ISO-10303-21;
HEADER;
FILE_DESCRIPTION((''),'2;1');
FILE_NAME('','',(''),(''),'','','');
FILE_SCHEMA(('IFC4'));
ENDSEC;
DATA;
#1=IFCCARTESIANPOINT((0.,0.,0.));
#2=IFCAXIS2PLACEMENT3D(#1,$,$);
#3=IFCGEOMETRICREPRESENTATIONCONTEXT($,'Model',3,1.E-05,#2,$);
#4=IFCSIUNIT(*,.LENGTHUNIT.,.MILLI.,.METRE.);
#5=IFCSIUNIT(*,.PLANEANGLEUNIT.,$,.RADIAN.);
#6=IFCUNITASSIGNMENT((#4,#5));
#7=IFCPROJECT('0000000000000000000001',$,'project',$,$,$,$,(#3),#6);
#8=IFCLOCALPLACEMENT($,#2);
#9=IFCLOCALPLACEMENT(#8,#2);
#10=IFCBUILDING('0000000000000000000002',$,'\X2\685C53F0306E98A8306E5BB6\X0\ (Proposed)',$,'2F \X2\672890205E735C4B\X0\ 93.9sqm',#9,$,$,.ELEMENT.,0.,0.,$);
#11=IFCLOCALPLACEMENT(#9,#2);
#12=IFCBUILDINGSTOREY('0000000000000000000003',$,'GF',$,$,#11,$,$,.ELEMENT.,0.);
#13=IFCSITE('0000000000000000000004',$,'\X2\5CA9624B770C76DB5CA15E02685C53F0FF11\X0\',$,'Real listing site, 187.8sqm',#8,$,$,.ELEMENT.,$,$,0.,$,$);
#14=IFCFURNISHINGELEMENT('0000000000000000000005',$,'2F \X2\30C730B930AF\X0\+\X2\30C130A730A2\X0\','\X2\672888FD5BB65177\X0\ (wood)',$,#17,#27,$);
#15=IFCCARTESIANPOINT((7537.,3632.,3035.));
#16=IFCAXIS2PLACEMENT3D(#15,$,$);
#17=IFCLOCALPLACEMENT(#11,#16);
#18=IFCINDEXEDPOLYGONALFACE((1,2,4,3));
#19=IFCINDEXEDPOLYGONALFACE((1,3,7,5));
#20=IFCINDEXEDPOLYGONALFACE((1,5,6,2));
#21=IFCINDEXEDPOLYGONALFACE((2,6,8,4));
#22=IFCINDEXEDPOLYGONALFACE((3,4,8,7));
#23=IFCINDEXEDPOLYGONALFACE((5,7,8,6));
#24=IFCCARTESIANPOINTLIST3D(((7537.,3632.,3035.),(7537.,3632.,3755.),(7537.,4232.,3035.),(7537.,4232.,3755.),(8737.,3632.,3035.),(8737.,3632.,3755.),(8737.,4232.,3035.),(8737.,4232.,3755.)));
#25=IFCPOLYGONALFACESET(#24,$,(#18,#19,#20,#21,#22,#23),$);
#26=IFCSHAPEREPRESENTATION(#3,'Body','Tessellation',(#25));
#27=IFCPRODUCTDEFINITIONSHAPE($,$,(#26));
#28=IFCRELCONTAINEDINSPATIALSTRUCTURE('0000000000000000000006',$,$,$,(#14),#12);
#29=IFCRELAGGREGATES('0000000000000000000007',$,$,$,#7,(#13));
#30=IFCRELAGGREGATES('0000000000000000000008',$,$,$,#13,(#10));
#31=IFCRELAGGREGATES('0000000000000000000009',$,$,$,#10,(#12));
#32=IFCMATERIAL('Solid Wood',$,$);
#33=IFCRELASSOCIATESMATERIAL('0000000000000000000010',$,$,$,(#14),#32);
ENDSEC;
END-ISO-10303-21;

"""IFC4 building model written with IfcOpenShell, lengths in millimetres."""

from ifc_helpers import new_model, si_unit, frame, frame_2d, origin, place, context, project, spatial, rectangle, extrude, material, element, save


model = new_model("IFC4")

# Units and contexts
model_context = context("Model", 3, precision=1e-05, world=origin())
ifc_project = project(units=[si_unit("LENGTHUNIT", "METRE", prefix="MILLI"), si_unit("PLANEANGLEUNIT", "RADIAN")], contexts=[model_context])

# Site, building, storey
site_placement = place(None, origin())
site = spatial("IfcSite", under=ifc_project, at=site_placement, Name="岩手県盛岡市桜台１", ObjectType="Real listing site, 187.8sqm", CompositionType="ELEMENT", RefElevation=0.0)
building_placement = place(site_placement, origin())
building = spatial("IfcBuilding", under=site, at=building_placement, Name="桜台の風の家 (Proposed)", ObjectType="2F 木造平屋 93.9sqm", CompositionType="ELEMENT", ElevationOfRefHeight=0.0, ElevationOfTerrain=0.0)
storey_placement = place(building_placement, origin())
storey = spatial("IfcBuildingStorey", under=building, at=storey_placement, Name="GF", CompositionType="ELEMENT", Elevation=0.0)

# Shared definitions
ifc_material_1 = material(Name="Solid Wood")

# Furnishing element
furnishing_1_placement = place(storey_placement, frame((7537.0, 3632.0, 3035.0)))
element("IfcFurnishingElement", 1, at=furnishing_1_placement, inside=storey, material=ifc_material_1, Name="2F デスク+チェア", Description="木製家具 (wood)", context=model_context, shape_type="SweptSolid", body=[
    extrude(rectangle(XDim=1200.0, YDim=600.0, at=frame_2d((600.0, 300.0))), frame((7537.0, 3632.0, 3035.0)), (0.0, 0.0, 1.0), 720.0),
])

save(model, "model.ifc")
